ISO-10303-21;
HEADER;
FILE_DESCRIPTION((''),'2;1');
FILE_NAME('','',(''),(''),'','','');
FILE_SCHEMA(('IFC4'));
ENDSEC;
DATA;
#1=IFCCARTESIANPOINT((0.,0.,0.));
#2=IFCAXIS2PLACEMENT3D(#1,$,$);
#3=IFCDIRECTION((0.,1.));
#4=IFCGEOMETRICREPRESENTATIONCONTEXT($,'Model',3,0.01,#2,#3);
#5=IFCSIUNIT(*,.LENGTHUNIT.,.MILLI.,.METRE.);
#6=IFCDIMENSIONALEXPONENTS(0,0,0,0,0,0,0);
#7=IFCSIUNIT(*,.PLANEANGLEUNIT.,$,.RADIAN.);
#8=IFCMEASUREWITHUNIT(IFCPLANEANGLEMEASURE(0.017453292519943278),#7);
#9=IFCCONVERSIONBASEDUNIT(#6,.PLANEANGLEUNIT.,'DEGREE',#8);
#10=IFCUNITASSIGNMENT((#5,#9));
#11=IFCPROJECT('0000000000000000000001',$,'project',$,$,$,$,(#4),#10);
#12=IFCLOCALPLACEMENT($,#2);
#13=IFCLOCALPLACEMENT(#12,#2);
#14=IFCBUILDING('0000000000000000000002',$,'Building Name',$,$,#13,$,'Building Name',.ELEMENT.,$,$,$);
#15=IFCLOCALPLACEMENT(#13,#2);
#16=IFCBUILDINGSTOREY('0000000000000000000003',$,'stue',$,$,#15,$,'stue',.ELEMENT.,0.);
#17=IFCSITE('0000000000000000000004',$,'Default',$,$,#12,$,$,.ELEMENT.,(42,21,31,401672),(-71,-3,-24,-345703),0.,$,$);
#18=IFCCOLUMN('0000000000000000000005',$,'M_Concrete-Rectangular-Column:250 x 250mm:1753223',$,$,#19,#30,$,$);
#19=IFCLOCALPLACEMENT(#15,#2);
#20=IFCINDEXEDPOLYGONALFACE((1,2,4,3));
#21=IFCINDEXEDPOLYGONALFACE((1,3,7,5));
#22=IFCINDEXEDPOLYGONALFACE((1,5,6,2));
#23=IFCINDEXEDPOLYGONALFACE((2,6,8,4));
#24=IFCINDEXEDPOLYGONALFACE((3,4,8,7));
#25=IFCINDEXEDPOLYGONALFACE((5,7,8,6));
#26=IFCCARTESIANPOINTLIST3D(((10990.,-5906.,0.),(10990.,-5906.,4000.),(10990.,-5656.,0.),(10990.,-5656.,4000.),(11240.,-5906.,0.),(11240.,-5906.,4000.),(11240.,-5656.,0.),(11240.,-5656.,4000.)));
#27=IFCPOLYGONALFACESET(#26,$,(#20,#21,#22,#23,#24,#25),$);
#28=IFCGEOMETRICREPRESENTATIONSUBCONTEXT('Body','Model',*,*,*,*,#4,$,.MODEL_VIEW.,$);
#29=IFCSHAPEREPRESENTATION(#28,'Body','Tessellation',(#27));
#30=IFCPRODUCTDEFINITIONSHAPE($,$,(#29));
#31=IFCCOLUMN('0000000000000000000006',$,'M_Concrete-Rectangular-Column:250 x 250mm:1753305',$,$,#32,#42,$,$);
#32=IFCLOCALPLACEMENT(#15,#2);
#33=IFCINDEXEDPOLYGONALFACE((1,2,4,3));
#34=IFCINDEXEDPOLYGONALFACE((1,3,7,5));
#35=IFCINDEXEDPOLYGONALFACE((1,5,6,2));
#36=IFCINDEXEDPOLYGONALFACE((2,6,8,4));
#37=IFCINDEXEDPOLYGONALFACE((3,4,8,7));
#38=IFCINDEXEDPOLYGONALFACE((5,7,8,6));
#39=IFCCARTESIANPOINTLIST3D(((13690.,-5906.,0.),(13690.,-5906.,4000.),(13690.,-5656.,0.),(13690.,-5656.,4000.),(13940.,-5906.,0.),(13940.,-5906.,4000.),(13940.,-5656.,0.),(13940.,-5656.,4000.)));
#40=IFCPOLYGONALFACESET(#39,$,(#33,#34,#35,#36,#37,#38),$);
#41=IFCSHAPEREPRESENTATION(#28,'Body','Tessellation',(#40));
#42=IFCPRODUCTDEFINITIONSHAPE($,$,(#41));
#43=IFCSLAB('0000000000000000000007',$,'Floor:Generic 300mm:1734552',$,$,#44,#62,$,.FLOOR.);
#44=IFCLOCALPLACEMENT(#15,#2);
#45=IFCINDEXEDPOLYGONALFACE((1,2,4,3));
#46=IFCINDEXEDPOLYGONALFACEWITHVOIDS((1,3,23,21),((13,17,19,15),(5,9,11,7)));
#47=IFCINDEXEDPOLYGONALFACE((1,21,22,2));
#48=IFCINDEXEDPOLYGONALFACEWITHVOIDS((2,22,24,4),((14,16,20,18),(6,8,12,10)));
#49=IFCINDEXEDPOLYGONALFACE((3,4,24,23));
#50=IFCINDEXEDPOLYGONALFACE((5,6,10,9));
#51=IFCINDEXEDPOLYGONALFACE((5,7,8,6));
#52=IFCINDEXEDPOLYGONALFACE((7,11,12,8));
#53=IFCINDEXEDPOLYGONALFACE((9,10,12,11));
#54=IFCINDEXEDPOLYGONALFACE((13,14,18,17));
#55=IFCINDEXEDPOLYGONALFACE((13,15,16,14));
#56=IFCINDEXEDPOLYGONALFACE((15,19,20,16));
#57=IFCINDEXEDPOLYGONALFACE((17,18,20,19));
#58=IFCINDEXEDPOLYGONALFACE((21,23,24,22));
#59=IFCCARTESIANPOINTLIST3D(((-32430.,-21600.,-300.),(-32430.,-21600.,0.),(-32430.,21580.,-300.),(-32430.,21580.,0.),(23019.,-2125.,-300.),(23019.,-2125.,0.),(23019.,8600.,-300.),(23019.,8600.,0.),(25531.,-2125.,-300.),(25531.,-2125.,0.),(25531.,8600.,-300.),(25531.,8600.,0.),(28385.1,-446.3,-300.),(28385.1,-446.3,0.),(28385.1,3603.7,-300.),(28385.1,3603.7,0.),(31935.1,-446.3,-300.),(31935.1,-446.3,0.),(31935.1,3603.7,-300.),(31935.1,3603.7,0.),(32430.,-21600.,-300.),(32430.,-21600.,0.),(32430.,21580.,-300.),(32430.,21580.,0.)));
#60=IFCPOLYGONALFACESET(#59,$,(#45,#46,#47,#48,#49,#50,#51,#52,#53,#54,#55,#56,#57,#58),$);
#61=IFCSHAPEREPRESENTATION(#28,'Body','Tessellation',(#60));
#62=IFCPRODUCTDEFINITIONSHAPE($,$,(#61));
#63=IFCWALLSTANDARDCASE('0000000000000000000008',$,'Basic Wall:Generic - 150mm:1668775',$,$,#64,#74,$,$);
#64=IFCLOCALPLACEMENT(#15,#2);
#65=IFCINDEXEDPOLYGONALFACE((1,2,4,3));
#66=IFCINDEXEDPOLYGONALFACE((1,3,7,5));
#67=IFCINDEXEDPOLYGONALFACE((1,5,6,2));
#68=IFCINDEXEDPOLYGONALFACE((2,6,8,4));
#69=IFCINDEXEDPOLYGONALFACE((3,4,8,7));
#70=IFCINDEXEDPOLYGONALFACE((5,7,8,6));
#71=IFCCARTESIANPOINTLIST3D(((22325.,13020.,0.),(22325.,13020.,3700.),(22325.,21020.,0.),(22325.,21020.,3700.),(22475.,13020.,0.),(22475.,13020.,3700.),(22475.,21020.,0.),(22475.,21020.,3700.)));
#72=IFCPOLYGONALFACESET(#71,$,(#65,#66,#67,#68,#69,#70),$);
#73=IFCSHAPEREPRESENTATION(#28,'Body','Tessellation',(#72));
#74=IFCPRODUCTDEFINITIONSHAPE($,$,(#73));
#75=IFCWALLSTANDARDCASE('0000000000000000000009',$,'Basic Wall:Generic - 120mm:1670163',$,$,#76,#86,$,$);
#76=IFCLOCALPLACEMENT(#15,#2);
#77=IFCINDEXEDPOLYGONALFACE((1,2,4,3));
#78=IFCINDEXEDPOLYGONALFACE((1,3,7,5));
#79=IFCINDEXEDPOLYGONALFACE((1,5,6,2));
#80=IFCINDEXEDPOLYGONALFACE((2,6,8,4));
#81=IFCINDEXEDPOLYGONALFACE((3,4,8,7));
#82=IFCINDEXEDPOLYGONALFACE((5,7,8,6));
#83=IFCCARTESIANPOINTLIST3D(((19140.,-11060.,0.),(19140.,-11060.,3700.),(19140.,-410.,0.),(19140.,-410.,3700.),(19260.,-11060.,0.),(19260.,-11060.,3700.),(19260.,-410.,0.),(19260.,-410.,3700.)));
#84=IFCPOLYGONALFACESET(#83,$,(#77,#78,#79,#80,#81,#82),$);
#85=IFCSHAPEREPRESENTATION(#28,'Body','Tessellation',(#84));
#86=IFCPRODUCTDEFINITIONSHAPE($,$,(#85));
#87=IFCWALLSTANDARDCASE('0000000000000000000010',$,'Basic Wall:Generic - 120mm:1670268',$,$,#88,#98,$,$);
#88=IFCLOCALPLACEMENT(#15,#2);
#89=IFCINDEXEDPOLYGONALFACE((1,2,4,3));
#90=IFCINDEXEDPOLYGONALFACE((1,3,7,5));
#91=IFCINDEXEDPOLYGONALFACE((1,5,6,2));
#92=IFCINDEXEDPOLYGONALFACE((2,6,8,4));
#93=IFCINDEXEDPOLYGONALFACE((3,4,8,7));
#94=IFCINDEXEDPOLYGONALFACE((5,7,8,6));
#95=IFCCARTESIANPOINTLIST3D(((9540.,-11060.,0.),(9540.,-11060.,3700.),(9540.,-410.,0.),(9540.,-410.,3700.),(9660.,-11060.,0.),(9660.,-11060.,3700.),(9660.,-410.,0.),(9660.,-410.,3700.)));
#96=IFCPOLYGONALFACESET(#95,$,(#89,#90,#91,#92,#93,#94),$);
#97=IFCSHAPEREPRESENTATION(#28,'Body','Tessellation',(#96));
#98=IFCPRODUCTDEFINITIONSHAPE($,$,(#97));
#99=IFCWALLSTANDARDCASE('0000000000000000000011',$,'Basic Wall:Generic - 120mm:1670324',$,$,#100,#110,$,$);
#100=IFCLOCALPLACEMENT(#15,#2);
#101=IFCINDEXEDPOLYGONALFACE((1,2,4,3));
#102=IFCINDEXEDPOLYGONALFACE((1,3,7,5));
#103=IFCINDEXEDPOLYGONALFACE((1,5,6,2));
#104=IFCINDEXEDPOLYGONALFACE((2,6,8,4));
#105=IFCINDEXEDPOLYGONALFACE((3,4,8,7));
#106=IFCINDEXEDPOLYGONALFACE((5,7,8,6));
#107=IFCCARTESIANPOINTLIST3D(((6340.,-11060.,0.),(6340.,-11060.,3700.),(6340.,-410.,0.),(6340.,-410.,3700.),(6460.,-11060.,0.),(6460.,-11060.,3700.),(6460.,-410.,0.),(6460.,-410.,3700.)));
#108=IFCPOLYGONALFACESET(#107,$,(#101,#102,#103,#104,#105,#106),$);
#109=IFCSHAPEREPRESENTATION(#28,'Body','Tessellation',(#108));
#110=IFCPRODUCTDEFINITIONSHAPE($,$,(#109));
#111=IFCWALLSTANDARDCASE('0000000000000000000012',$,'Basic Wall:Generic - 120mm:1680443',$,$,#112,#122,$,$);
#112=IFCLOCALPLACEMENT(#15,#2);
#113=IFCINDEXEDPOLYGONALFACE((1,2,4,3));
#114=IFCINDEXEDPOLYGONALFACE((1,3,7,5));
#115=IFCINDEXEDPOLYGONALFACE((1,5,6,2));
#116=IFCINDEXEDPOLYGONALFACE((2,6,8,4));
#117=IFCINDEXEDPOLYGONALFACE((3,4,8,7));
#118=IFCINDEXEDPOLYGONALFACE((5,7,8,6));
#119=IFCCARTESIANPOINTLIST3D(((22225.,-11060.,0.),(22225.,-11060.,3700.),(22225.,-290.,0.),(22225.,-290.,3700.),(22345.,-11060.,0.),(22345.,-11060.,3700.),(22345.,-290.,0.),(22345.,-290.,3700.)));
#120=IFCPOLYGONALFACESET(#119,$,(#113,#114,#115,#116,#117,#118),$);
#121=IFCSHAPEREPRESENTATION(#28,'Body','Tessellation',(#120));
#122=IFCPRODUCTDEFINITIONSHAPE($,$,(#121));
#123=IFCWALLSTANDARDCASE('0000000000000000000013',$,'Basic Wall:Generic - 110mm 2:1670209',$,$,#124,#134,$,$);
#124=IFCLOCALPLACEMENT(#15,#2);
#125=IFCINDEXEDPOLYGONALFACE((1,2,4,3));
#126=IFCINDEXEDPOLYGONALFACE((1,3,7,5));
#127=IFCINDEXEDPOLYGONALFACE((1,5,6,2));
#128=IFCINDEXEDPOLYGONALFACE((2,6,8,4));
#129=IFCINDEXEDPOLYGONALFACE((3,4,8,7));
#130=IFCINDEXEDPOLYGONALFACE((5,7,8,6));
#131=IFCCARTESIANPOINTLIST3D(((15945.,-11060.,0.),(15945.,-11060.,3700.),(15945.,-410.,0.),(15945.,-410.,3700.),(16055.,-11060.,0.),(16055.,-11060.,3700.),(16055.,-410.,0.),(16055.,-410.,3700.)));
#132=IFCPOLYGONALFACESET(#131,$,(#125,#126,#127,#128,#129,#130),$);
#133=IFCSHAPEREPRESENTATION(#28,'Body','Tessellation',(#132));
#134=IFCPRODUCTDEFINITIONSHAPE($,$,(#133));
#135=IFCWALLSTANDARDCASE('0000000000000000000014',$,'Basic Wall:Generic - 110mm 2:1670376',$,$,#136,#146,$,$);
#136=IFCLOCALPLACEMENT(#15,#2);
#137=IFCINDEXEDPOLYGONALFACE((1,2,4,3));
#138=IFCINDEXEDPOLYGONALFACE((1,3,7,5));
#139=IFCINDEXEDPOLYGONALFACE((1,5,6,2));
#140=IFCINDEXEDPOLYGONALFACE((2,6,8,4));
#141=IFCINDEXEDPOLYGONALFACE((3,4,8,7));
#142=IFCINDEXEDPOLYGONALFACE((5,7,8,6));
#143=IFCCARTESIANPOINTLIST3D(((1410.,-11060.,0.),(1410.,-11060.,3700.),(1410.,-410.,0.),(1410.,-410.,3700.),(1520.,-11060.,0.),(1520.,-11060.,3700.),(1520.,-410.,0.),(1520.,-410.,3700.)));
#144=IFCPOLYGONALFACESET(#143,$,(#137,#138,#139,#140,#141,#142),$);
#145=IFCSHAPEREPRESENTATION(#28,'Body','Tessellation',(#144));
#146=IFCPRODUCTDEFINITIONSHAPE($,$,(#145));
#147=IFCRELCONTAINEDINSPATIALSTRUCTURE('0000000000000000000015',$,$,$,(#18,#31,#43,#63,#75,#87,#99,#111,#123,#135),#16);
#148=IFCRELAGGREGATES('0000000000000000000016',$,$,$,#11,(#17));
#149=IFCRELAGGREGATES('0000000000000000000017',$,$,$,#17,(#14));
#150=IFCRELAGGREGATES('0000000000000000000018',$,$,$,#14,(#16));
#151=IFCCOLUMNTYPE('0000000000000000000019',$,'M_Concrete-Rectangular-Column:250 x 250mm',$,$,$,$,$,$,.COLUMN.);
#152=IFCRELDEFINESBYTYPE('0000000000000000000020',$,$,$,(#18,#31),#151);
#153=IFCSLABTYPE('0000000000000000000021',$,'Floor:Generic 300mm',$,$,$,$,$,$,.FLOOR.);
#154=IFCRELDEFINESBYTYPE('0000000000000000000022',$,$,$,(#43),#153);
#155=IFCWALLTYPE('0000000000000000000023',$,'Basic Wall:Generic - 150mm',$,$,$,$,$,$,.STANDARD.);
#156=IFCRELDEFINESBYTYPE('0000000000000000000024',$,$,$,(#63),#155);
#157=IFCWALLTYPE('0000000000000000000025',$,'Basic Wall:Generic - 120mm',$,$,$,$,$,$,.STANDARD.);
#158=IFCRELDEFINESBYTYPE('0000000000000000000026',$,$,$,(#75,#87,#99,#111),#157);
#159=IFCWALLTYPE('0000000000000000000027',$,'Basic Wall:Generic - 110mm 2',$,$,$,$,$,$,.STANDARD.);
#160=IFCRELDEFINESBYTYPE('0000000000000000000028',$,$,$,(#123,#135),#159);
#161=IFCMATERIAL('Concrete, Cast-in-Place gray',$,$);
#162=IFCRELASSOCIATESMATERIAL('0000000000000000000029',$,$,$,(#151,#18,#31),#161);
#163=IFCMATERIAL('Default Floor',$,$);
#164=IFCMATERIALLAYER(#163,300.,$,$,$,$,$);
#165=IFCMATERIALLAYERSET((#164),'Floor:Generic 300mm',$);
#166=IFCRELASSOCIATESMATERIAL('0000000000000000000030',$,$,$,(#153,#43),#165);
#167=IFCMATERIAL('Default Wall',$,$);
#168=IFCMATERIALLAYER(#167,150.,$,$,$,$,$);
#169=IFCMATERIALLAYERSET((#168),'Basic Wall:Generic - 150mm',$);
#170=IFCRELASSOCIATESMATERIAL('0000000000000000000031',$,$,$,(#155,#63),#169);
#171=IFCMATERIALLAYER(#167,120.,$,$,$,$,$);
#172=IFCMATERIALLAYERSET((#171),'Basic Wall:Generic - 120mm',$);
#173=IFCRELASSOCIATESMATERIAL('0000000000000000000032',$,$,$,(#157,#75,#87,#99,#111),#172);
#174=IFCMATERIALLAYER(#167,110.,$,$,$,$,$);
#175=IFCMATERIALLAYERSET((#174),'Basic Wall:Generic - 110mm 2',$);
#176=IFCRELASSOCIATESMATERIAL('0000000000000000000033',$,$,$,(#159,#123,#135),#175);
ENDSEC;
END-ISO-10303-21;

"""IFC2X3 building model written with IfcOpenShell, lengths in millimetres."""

from ifc_helpers import new_model, entity, si_unit, converted_unit, direction, frame, frame_2d, origin, origin_2d_with_axis, place, context, subcontext, project, spatial, polyline, rectangle, extrude, boolean, clip, bounded_halfspace, source, transform, mapped, material, layer, layer_set, layer_usage, type_object, type_shapes, element, save


model = new_model("IFC2X3")

# Units and contexts
model_context = context("Model", 3, precision=0.01, world=origin(), true_north=direction((0.0, 1.0)))
body_context = subcontext(model_context, "Body", "Model", "MODEL_VIEW")
ifc_project = project(units=[si_unit("LENGTHUNIT", "METRE", prefix="MILLI"), converted_unit("PLANEANGLEUNIT", "DEGREE", entity("IfcPlaneAngleMeasure", 0.017453292519943278), si_unit("PLANEANGLEUNIT", "RADIAN"), dimensions=[0, 0, 0, 0, 0, 0, 0])], contexts=[model_context])

# Site, building, storey
site_placement = place(None, origin())
site = spatial("IfcSite", under=ifc_project, at=site_placement, Name="Default", CompositionType="ELEMENT", RefLatitude=(42, 21, 31, 401672), RefLongitude=(-71, -3, -24, -345703), RefElevation=0.0)
building_placement = place(site_placement, origin())
building = spatial("IfcBuilding", under=site, at=building_placement, Name="Building Name", LongName="Building Name", CompositionType="ELEMENT")
storey_placement = place(building_placement, origin())
storey = spatial("IfcBuildingStorey", under=building, at=storey_placement, Name="stue", LongName="stue", CompositionType="ELEMENT", Elevation=0.0)

# Columns
ifc_material_1 = material(Name="Concrete, Cast-in-Place gray")
column_type = type_object("IfcColumnType", Name="M_Concrete-Rectangular-Column:250 x 250mm", PredefinedType="COLUMN", material=ifc_material_1)
shared_shape = source(origin(), body_context, "Body", "SweptSolid", [
    extrude(rectangle(XDim=250.0, YDim=250.0, at=origin_2d_with_axis()), frame((0.0, 0.0, 0.0), z_axis=(0.0, 0.0, 1.0), x_axis=(-1.0, 0.0, 0.0)), (0.0, 0.0, 1.0), 4000.0),
])
type_shapes(column_type, [shared_shape])
for number, where, name in (
    (1, (11115.0, -5781.0, 0.0), "M_Concrete-Rectangular-Column:250 x 250mm:1753223"),
    (2, (13815.0, -5781.0, 0.0), "M_Concrete-Rectangular-Column:250 x 250mm:1753305"),
):
    element("IfcColumn", number, at=place(storey_placement, frame(where)), inside=storey, type_object=column_type, material=ifc_material_1, Name=name, context=body_context, shape_type="MappedRepresentation", body=[
        mapped(shared_shape, transform((0.0, 0.0, 0.0), scale=1.0)),
    ])

# Slab, openings
ifc_material_2 = material(Name="Default Floor")
ifc_layer_1 = layer(ifc_material_2, 300.0)
ifc_layer_set_1 = layer_set([ifc_layer_1], Name="Floor:Generic 300mm")
ifc_layer_usage_1 = layer_usage(ifc_layer_set_1, "AXIS3", "POSITIVE", 0.0)
slab_type = type_object("IfcSlabType", Name="Floor:Generic 300mm", PredefinedType="FLOOR", material=ifc_layer_set_1)
slab_placement = place(storey_placement, origin())
slab = element("IfcSlab", 3, at=slab_placement, inside=storey, type_object=slab_type, material=ifc_layer_usage_1, Name="Floor:Generic 300mm:1734552", PredefinedType="FLOOR", context=body_context, shape_type="CSG", body=[
    boolean("DIFFERENCE", boolean("DIFFERENCE", extrude(rectangle(XDim=43180.0, YDim=64860.0, at=origin_2d_with_axis()), frame((0.0, -10.0, 0.0), z_axis=(0.0, 0.0, -1.0), x_axis=(0.0, 1.0, 0.0)), (0.0, 0.0, 1.0), 300.0), extrude(rectangle(XDim=10725.0, YDim=2512.0, at=origin_2d_with_axis()), frame((24275.0, 3237.5, -300.0), z_axis=(0.0, 0.0, 1.0), x_axis=(0.0, 1.0, 0.0)), (0.0, 0.0, 1.0), 300.0)), extrude(rectangle(XDim=4050.0, YDim=3550.0, at=frame_2d((0.0, 0.0), x_axis=(1.0, 0.0))), frame((30160.1, 1578.7, -300.0), z_axis=(0.0, 0.0, 1.0), x_axis=(0.0, 1.0, 0.0)), (0.0, 0.0, 1.0), 300.0)),
])
opening_1_placement = place(slab_placement, origin())
element("IfcOpeningElement", 4, at=opening_1_placement, cuts=slab, ObjectType="Opening", context=body_context, shape_type="SweptSolid", body=[
    extrude(rectangle(XDim=4050.0, YDim=3550.0, at=frame_2d((30160.1, 1578.7), x_axis=(0.0, -1.0))), origin(), (0.0, 0.0, -1.0), 300.0),
])
opening_2_placement = place(slab_placement, origin())
element("IfcOpeningElement", 5, at=opening_2_placement, cuts=slab, ObjectType="Opening", context=body_context, shape_type="SweptSolid", body=[
    extrude(rectangle(XDim=10725.0, YDim=2512.0, at=frame_2d((24275.0, 3237.5), x_axis=(0.0, -1.0))), origin(), (0.0, 0.0, -1.0), 300.0),
])

# Walls
ifc_material_3 = material(Name="Default Wall")
ifc_layer_2 = layer(ifc_material_3, 150.0)
ifc_layer_set_2 = layer_set([ifc_layer_2], Name="Basic Wall:Generic - 150mm")
ifc_layer_usage_2 = layer_usage(ifc_layer_set_2, "AXIS2", "NEGATIVE", 75.0)
wall_type_1 = type_object("IfcWallType", Name="Basic Wall:Generic - 150mm", PredefinedType="STANDARD", material=ifc_layer_set_2)
wall_1_placement = place(storey_placement, frame((22400.0, 13020.0, 0.0), z_axis=(0.0, 0.0, 1.0), x_axis=(0.0, 1.0, 0.0)))
element("IfcWallStandardCase", 6, at=wall_1_placement, inside=storey, type_object=wall_type_1, material=ifc_layer_usage_2, Name="Basic Wall:Generic - 150mm:1668775", context=body_context, shape_type="Clipping", body=[
    clip(extrude(rectangle(XDim=8000.0, YDim=150.0, at=frame_2d((4000.0, 0.0), x_axis=(-1.0, 0.0))), origin(), (0.0, 0.0, 1.0), 3700.0), bounded_halfspace(frame((0.0, -75.0, 3700.0), z_axis=(0.0, 0.0, -1.0), x_axis=(-1.0, 0.0, 0.0)), True, frame((0.0, -75.0, 3700.0)), polyline([(0.0, 0.0), (8000.0, 0.0), (8000.0, 150.0), (1405.5, 150.0), (1308.5, 150.0), (0.0, 150.0), (0.0, 0.0)]))),
])
ifc_layer_3 = layer(ifc_material_3, 120.0)
ifc_layer_set_3 = layer_set([ifc_layer_3], Name="Basic Wall:Generic - 120mm")
ifc_layer_usage_3 = layer_usage(ifc_layer_set_3, "AXIS2", "NEGATIVE", 60.0)
wall_type_2 = type_object("IfcWallType", Name="Basic Wall:Generic - 120mm", PredefinedType="STANDARD", material=ifc_layer_set_3)
wall_2_placement = place(storey_placement, frame((19200.0, -410.0, 0.0), z_axis=(0.0, 0.0, 1.0), x_axis=(0.0, -1.0, 0.0)))
element("IfcWallStandardCase", 7, at=wall_2_placement, inside=storey, type_object=wall_type_2, material=ifc_layer_usage_3, Name="Basic Wall:Generic - 120mm:1670163", context=body_context, shape_type="Clipping", body=[
    clip(extrude(rectangle(XDim=10650.0, YDim=120.0, at=frame_2d((5325.0, 0.0), x_axis=(-1.0, 0.0))), origin(), (0.0, 0.0, 1.0), 3700.0), bounded_halfspace(frame((0.0, -60.0, 3700.0), z_axis=(0.0, 0.0, -1.0), x_axis=(1.0, 0.0, 0.0)), True, frame((0.0, -60.0, 3700.0)), polyline([(0.0, 0.0), (10650.0, 0.0), (10650.0, 120.0), (0.0, 120.0), (0.0, 0.0)]))),
])
ifc_layer_usage_4 = layer_usage(ifc_layer_set_3, "AXIS2", "NEGATIVE", 60.0)
wall_3_placement = place(storey_placement, frame((9600.0, -410.0, 0.0), z_axis=(0.0, 0.0, 1.0), x_axis=(0.0, -1.0, 0.0)))
element("IfcWallStandardCase", 8, at=wall_3_placement, inside=storey, type_object=wall_type_2, material=ifc_layer_usage_4, Name="Basic Wall:Generic - 120mm:1670268", context=body_context, shape_type="Clipping", body=[
    clip(extrude(rectangle(XDim=10650.0, YDim=120.0, at=frame_2d((5325.0, 0.0), x_axis=(-1.0, 0.0))), origin(), (0.0, 0.0, 1.0), 3700.0), bounded_halfspace(frame((0.0, -60.0, 3700.0), z_axis=(0.0, 0.0, -1.0), x_axis=(1.0, 0.0, 0.0)), True, frame((0.0, -60.0, 3700.0)), polyline([(0.0, 0.0), (10650.0, 0.0), (10650.0, 120.0), (5599.0, 120.0), (5485.0, 120.0), (0.0, 120.0), (0.0, 0.0)]))),
])
ifc_layer_usage_5 = layer_usage(ifc_layer_set_3, "AXIS2", "NEGATIVE", 60.0)
wall_4_placement = place(storey_placement, frame((6400.0, -410.0, 0.0), z_axis=(0.0, 0.0, 1.0), x_axis=(0.0, -1.0, 0.0)))
element("IfcWallStandardCase", 9, at=wall_4_placement, inside=storey, type_object=wall_type_2, material=ifc_layer_usage_5, Name="Basic Wall:Generic - 120mm:1670324", context=body_context, shape_type="Clipping", body=[
    clip(extrude(rectangle(XDim=10650.0, YDim=120.0, at=frame_2d((5325.0, 0.0), x_axis=(-1.0, 0.0))), origin(), (0.0, 0.0, 1.0), 3700.0), bounded_halfspace(frame((0.0, -60.0, 3700.0), z_axis=(0.0, 0.0, -1.0), x_axis=(1.0, 0.0, 0.0)), True, frame((0.0, -60.0, 3700.0)), polyline([(0.0, 0.0), (10650.0, 0.0), (10650.0, 120.0), (0.0, 120.0), (0.0, 0.0)]))),
])
ifc_layer_usage_6 = layer_usage(ifc_layer_set_3, "AXIS2", "NEGATIVE", 60.0)
wall_5_placement = place(storey_placement, frame((22285.0, -290.0, 0.0), z_axis=(0.0, 0.0, 1.0), x_axis=(0.0, -1.0, 0.0)))
element("IfcWallStandardCase", 10, at=wall_5_placement, inside=storey, type_object=wall_type_2, material=ifc_layer_usage_6, Name="Basic Wall:Generic - 120mm:1680443", context=body_context, shape_type="Clipping", body=[
    clip(extrude(rectangle(XDim=10770.0, YDim=120.0, at=frame_2d((5385.0, 0.0), x_axis=(-1.0, 0.0))), origin(), (0.0, 0.0, 1.0), 3700.0), bounded_halfspace(frame((0.0, -60.0, 3700.0), z_axis=(0.0, 0.0, -1.0), x_axis=(1.0, 0.0, 0.0)), True, frame((0.0, -60.0, 3700.0)), polyline([(0.0, 0.0), (10770.0, 0.0), (10770.0, 120.0), (483.5, 120.0), (253.5, 120.0), (0.0, 120.0), (0.0, 0.0)]))),
])
ifc_layer_4 = layer(ifc_material_3, 110.0)
ifc_layer_set_4 = layer_set([ifc_layer_4], Name="Basic Wall:Generic - 110mm 2")
ifc_layer_usage_7 = layer_usage(ifc_layer_set_4, "AXIS2", "NEGATIVE", 55.0)
wall_type_3 = type_object("IfcWallType", Name="Basic Wall:Generic - 110mm 2", PredefinedType="STANDARD", material=ifc_layer_set_4)
wall_6_placement = place(storey_placement, frame((16000.0, -410.0, 0.0), z_axis=(0.0, 0.0, 1.0), x_axis=(0.0, -1.0, 0.0)))
element("IfcWallStandardCase", 11, at=wall_6_placement, inside=storey, type_object=wall_type_3, material=ifc_layer_usage_7, Name="Basic Wall:Generic - 110mm 2:1670209", context=body_context, shape_type="Clipping", body=[
    clip(extrude(rectangle(XDim=10650.0, YDim=110.0, at=frame_2d((5325.0, 0.0), x_axis=(-1.0, 0.0))), origin(), (0.0, 0.0, 1.0), 3700.0), bounded_halfspace(frame((0.0, -55.0, 3700.0), z_axis=(0.0, 0.0, -1.0), x_axis=(1.0, 0.0, 0.0)), True, frame((0.0, -55.0, 3700.0)), polyline([(0.0, 0.0), (5485.0, 0.0), (5599.0, 0.0), (10650.0, 0.0), (10650.0, 110.0), (0.0, 110.0), (0.0, 0.0)]))),
])
ifc_layer_usage_8 = layer_usage(ifc_layer_set_4, "AXIS2", "NEGATIVE", 55.0)
wall_7_placement = place(storey_placement, frame((1465.0, -410.0, 0.0), z_axis=(0.0, 0.0, 1.0), x_axis=(0.0, -1.0, 0.0)))
element("IfcWallStandardCase", 12, at=wall_7_placement, inside=storey, type_object=wall_type_3, material=ifc_layer_usage_8, Name="Basic Wall:Generic - 110mm 2:1670376", context=body_context, shape_type="Clipping", body=[
    clip(extrude(rectangle(XDim=10650.0, YDim=110.0, at=frame_2d((5325.0, 0.0), x_axis=(-1.0, 0.0))), origin(), (0.0, 0.0, 1.0), 3700.0), bounded_halfspace(frame((0.0, -55.0, 3700.0), z_axis=(0.0, 0.0, -1.0), x_axis=(1.0, 0.0, 0.0)), True, frame((0.0, -55.0, 3700.0)), polyline([(0.0, 0.0), (5105.0, 0.0), (5219.0, 0.0), (10650.0, 0.0), (10650.0, 110.0), (0.0, 110.0), (0.0, 0.0)]))),
])

save(model, "model.ifc")
